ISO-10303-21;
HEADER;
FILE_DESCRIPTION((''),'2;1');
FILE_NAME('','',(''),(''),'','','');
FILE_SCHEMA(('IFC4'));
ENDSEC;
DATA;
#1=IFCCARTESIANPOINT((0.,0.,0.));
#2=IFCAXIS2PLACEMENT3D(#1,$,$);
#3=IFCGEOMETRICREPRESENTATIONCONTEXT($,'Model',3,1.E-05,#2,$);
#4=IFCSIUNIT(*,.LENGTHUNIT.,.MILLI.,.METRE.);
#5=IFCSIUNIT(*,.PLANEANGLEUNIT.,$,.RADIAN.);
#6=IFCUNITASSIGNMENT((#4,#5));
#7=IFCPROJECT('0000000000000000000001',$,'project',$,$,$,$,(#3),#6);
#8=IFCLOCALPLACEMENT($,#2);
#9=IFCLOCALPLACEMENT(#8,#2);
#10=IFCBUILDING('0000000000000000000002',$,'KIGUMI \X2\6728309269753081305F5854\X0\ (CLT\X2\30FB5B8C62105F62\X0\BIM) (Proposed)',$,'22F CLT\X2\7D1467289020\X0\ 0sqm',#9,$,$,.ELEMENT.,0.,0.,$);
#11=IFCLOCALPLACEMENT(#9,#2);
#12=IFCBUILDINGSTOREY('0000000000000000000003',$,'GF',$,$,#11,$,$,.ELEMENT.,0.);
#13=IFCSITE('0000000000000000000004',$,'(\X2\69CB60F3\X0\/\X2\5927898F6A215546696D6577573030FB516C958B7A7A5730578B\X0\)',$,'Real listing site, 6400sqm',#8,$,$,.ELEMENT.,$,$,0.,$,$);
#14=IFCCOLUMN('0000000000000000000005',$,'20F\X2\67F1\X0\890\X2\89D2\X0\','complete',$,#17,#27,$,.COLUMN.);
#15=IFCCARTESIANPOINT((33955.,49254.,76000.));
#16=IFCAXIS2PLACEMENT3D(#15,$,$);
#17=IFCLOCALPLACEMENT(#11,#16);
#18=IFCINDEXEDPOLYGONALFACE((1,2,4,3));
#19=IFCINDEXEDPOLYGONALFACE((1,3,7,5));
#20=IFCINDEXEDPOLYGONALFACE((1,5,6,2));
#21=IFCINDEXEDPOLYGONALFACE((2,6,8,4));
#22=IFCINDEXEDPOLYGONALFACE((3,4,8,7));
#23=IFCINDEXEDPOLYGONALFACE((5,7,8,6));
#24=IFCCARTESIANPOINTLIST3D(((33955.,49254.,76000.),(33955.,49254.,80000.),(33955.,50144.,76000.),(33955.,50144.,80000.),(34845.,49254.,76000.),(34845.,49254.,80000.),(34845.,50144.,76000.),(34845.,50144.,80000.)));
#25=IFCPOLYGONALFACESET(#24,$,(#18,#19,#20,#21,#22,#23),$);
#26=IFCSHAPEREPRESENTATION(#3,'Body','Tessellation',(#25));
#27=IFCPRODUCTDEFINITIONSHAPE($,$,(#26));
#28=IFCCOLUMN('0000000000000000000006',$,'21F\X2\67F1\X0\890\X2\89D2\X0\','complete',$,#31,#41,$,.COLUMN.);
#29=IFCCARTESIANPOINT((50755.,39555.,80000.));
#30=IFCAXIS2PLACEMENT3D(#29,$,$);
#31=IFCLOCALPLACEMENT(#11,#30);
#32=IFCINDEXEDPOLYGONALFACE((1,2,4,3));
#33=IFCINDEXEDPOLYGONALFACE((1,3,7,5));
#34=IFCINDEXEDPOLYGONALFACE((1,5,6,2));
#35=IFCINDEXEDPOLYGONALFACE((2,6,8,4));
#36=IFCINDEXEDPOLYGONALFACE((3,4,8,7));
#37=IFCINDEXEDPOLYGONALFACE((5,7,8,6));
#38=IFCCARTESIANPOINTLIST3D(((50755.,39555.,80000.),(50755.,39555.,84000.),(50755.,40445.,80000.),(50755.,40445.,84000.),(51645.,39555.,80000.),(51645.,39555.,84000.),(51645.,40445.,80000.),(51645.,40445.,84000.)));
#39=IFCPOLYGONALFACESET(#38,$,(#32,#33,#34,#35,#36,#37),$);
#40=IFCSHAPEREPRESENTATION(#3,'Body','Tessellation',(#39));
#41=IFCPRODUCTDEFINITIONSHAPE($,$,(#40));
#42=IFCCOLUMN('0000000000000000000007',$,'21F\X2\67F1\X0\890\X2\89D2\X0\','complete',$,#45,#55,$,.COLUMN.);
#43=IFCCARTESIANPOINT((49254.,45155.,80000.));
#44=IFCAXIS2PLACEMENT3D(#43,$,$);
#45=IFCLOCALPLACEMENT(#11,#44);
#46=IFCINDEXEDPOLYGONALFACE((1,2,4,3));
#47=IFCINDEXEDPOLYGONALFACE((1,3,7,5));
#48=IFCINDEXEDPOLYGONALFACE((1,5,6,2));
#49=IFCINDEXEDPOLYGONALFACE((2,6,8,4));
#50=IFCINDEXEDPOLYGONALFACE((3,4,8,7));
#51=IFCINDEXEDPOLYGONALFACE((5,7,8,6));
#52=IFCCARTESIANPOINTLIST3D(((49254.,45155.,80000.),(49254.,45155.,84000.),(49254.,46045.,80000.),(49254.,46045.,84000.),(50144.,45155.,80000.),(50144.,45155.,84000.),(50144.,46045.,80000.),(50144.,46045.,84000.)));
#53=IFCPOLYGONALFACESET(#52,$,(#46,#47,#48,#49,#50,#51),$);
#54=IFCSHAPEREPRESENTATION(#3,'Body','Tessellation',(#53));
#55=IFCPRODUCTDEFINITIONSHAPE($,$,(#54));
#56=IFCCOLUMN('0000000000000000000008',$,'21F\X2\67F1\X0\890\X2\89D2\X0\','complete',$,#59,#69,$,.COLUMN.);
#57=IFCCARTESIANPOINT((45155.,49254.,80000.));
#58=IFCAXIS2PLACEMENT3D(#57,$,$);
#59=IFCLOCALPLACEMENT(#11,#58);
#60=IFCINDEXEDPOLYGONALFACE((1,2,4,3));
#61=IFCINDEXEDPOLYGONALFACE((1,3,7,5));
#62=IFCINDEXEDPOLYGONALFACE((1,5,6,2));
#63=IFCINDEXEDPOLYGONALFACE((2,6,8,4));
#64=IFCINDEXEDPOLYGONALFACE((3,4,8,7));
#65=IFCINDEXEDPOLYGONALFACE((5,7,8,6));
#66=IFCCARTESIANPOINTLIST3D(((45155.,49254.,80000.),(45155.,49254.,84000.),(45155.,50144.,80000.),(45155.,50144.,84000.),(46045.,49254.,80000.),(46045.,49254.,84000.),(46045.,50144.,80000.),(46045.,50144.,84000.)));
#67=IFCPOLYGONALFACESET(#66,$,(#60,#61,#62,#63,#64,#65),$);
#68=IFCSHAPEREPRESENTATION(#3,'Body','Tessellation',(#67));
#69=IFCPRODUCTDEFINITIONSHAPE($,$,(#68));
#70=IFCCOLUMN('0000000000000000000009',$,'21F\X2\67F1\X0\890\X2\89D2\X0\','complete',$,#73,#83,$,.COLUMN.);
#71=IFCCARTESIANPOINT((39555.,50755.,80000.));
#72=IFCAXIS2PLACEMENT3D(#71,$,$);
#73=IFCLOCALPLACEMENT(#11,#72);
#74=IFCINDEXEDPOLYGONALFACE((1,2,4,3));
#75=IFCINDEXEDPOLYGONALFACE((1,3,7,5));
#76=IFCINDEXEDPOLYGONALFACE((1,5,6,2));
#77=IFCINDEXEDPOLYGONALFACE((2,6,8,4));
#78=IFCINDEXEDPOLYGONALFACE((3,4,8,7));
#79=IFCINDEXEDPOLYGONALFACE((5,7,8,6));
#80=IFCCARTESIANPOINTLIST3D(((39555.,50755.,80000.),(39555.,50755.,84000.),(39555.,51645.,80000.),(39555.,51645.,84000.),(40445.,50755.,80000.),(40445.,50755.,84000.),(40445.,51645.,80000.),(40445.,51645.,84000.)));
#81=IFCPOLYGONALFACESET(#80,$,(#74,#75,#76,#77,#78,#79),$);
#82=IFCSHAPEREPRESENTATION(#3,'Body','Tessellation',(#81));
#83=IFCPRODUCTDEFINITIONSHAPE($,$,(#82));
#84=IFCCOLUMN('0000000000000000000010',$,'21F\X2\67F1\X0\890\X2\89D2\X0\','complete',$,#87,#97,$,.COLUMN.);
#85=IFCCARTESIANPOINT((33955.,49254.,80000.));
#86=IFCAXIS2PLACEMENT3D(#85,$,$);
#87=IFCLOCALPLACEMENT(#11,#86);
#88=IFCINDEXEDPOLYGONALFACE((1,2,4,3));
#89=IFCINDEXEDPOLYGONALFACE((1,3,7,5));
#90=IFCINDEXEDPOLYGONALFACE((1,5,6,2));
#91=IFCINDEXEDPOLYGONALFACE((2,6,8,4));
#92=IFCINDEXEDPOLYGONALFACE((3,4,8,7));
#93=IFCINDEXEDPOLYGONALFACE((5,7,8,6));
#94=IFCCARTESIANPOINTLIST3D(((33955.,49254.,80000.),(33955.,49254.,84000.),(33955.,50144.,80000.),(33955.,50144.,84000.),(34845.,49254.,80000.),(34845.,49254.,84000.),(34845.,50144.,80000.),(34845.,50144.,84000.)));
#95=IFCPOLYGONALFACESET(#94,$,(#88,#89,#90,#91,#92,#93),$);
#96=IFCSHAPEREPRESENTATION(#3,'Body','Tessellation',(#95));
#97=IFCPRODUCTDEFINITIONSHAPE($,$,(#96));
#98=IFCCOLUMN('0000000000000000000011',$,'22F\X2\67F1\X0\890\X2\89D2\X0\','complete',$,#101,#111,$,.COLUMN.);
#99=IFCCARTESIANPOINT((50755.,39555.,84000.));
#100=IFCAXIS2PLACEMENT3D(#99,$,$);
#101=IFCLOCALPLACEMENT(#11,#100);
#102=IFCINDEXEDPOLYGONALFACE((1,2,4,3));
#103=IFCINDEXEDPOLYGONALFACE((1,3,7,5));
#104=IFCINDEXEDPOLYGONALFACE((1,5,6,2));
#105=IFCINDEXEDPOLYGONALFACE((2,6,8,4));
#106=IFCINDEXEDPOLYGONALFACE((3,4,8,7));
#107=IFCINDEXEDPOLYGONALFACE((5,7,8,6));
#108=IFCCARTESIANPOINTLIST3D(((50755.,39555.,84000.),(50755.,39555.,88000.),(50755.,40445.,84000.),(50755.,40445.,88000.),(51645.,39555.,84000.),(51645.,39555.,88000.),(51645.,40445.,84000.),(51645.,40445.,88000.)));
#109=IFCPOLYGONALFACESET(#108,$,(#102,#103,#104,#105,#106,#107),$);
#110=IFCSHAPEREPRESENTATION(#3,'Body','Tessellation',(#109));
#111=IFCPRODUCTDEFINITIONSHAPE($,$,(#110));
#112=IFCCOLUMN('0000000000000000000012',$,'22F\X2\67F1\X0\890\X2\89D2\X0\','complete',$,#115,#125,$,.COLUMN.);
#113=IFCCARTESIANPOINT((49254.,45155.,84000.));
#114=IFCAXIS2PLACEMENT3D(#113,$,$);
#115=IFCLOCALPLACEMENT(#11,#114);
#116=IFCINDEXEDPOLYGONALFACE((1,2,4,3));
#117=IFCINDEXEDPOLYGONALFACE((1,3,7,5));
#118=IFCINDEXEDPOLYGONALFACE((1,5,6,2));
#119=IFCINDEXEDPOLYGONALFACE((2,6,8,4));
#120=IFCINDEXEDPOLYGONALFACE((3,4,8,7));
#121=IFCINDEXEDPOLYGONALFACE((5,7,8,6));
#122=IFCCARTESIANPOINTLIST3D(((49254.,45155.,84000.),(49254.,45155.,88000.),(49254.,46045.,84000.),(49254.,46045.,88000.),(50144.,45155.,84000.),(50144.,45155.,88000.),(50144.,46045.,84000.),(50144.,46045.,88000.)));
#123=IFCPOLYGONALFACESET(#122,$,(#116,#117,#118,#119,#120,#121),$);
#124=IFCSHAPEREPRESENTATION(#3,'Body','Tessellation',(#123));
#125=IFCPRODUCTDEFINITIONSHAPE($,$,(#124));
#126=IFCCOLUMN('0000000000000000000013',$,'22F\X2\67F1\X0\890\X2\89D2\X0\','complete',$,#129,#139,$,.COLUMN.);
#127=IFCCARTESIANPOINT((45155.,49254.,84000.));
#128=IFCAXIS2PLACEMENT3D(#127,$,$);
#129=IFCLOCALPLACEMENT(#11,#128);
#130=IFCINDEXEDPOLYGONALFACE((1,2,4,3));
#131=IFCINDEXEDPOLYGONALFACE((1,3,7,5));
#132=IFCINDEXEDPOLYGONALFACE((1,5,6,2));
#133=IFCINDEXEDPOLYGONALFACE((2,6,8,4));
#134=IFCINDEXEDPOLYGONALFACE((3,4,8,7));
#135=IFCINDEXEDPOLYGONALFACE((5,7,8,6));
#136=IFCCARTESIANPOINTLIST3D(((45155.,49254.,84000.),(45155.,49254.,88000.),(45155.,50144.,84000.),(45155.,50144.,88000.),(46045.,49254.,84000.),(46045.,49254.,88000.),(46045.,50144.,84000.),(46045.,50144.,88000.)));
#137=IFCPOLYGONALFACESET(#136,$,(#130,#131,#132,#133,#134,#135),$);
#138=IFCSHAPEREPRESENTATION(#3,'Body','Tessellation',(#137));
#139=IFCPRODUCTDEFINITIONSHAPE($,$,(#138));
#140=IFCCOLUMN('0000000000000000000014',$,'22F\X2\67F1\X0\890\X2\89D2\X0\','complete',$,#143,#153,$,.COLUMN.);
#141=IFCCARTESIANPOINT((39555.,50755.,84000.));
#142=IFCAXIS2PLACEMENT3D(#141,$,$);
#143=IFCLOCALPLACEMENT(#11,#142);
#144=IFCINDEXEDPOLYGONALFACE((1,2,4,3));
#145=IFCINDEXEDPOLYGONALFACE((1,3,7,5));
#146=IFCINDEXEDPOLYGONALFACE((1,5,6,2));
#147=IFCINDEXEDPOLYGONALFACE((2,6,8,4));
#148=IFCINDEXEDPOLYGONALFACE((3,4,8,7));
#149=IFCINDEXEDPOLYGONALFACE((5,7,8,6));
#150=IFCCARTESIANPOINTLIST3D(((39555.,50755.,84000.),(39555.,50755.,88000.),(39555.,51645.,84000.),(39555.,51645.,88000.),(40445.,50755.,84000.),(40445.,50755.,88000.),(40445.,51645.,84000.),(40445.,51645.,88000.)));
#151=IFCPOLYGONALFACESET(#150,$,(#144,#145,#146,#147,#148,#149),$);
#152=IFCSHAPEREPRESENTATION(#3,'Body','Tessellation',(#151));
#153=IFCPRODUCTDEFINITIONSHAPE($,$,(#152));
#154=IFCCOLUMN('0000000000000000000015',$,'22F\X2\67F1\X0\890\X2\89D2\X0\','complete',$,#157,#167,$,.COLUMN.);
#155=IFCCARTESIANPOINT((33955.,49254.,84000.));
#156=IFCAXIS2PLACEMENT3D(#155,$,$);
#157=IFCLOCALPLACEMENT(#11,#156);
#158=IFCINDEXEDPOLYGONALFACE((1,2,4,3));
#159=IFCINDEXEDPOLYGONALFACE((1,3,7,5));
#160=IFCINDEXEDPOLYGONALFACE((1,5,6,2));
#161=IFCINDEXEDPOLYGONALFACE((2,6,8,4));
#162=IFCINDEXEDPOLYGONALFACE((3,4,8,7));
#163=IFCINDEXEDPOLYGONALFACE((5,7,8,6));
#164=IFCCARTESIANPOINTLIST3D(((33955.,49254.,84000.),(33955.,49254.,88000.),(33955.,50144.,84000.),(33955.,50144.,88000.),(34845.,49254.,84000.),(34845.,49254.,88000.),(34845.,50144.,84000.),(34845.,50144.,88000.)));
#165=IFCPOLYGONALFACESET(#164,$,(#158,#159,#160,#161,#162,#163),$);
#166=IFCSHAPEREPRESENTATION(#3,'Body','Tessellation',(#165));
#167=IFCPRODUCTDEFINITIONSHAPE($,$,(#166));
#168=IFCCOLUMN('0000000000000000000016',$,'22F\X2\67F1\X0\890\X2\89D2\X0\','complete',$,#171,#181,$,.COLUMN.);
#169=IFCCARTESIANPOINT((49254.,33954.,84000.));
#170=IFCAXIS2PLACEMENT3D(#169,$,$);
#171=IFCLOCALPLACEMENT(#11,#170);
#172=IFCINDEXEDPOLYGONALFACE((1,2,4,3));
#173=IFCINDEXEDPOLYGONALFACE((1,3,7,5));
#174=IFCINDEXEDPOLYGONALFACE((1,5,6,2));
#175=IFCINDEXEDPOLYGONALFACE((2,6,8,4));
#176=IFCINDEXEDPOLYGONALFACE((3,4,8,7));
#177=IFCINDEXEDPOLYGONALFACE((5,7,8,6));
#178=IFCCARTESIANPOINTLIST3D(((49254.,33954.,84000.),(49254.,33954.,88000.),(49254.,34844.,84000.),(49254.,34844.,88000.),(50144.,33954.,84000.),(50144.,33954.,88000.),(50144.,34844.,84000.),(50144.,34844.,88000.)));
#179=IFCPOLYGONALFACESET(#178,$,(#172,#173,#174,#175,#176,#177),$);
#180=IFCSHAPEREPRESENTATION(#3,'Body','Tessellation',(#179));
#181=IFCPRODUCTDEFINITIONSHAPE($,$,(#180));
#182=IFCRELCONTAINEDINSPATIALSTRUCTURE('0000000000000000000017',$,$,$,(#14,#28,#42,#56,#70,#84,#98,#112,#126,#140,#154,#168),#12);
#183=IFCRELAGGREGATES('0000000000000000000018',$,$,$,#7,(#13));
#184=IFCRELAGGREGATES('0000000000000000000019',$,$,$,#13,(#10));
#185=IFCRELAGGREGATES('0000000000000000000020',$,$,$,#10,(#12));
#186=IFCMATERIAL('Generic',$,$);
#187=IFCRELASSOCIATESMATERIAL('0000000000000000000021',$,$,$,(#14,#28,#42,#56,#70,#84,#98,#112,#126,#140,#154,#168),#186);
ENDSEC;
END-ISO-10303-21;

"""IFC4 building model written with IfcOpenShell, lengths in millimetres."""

from ifc_helpers import new_model, si_unit, frame, frame_2d, origin, place, context, project, spatial, rectangle, extrude, material, element, save


model = new_model("IFC4")

# Units and contexts
model_context = context("Model", 3, precision=1e-05, world=origin())
ifc_project = project(units=[si_unit("LENGTHUNIT", "METRE", prefix="MILLI"), si_unit("PLANEANGLEUNIT", "RADIAN")], contexts=[model_context])

# Site, building, storey
site_placement = place(None, origin())
site = spatial("IfcSite", under=ifc_project, at=site_placement, Name="(構想/大規模商業敷地・公開空地型)", ObjectType="Real listing site, 6400sqm", CompositionType="ELEMENT", RefElevation=0.0)
building_placement = place(site_placement, origin())
building = spatial("IfcBuilding", under=site, at=building_placement, Name="KIGUMI 木を極めた塔 (CLT・完成形BIM) (Proposed)", ObjectType="22F CLT純木造 0sqm", CompositionType="ELEMENT", ElevationOfRefHeight=0.0, ElevationOfTerrain=0.0)
storey_placement = place(building_placement, origin())
storey = spatial("IfcBuildingStorey", under=building, at=storey_placement, Name="GF", CompositionType="ELEMENT", Elevation=0.0)

# Columns
ifc_material = material(Name="Generic")
column_1_placement = place(storey_placement, frame((33955.0, 49254.0, 76000.0)))
element("IfcColumn", 1, at=column_1_placement, inside=storey, material=ifc_material, Name="20F柱890角", Description="complete", PredefinedType="COLUMN", context=model_context, shape_type="SweptSolid", body=[
    extrude(rectangle(XDim=890.0, YDim=890.0, at=frame_2d((445.0, 445.0))), frame((33955.0, 49254.0, 76000.0)), (0.0, 0.0, 1.0), 4000.0),
])
column_2_placement = place(storey_placement, frame((50755.0, 39555.0, 80000.0)))
element("IfcColumn", 2, at=column_2_placement, inside=storey, material=ifc_material, Name="21F柱890角", Description="complete", PredefinedType="COLUMN", context=model_context, shape_type="SweptSolid", body=[
    extrude(rectangle(XDim=890.0, YDim=890.0, at=frame_2d((445.0, 445.0))), frame((50755.0, 39555.0, 80000.0)), (0.0, 0.0, 1.0), 4000.0),
])
column_3_placement = place(storey_placement, frame((49254.0, 45155.0, 80000.0)))
element("IfcColumn", 3, at=column_3_placement, inside=storey, material=ifc_material, Name="21F柱890角", Description="complete", PredefinedType="COLUMN", context=model_context, shape_type="SweptSolid", body=[
    extrude(rectangle(XDim=890.0, YDim=890.0, at=frame_2d((445.0, 445.0))), frame((49254.0, 45155.0, 80000.0)), (0.0, 0.0, 1.0), 4000.0),
])
column_4_placement = place(storey_placement, frame((45155.0, 49254.0, 80000.0)))
element("IfcColumn", 4, at=column_4_placement, inside=storey, material=ifc_material, Name="21F柱890角", Description="complete", PredefinedType="COLUMN", context=model_context, shape_type="SweptSolid", body=[
    extrude(rectangle(XDim=890.0, YDim=890.0, at=frame_2d((445.0, 445.0))), frame((45155.0, 49254.0, 80000.0)), (0.0, 0.0, 1.0), 4000.0),
])
column_5_placement = place(storey_placement, frame((39555.0, 50755.0, 80000.0)))
element("IfcColumn", 5, at=column_5_placement, inside=storey, material=ifc_material, Name="21F柱890角", Description="complete", PredefinedType="COLUMN", context=model_context, shape_type="SweptSolid", body=[
    extrude(rectangle(XDim=890.0, YDim=890.0, at=frame_2d((445.0, 445.0))), frame((39555.0, 50755.0, 80000.0)), (0.0, 0.0, 1.0), 4000.0),
])
column_6_placement = place(storey_placement, frame((33955.0, 49254.0, 80000.0)))
element("IfcColumn", 6, at=column_6_placement, inside=storey, material=ifc_material, Name="21F柱890角", Description="complete", PredefinedType="COLUMN", context=model_context, shape_type="SweptSolid", body=[
    extrude(rectangle(XDim=890.0, YDim=890.0, at=frame_2d((445.0, 445.0))), frame((33955.0, 49254.0, 80000.0)), (0.0, 0.0, 1.0), 4000.0),
])
column_7_placement = place(storey_placement, frame((50755.0, 39555.0, 84000.0)))
element("IfcColumn", 7, at=column_7_placement, inside=storey, material=ifc_material, Name="22F柱890角", Description="complete", PredefinedType="COLUMN", context=model_context, shape_type="SweptSolid", body=[
    extrude(rectangle(XDim=890.0, YDim=890.0, at=frame_2d((445.0, 445.0))), frame((50755.0, 39555.0, 84000.0)), (0.0, 0.0, 1.0), 4000.0),
])
column_8_placement = place(storey_placement, frame((49254.0, 45155.0, 84000.0)))
element("IfcColumn", 8, at=column_8_placement, inside=storey, material=ifc_material, Name="22F柱890角", Description="complete", PredefinedType="COLUMN", context=model_context, shape_type="SweptSolid", body=[
    extrude(rectangle(XDim=890.0, YDim=890.0, at=frame_2d((445.0, 445.0))), frame((49254.0, 45155.0, 84000.0)), (0.0, 0.0, 1.0), 4000.0),
])
column_9_placement = place(storey_placement, frame((45155.0, 49254.0, 84000.0)))
element("IfcColumn", 9, at=column_9_placement, inside=storey, material=ifc_material, Name="22F柱890角", Description="complete", PredefinedType="COLUMN", context=model_context, shape_type="SweptSolid", body=[
    extrude(rectangle(XDim=890.0, YDim=890.0, at=frame_2d((445.0, 445.0))), frame((45155.0, 49254.0, 84000.0)), (0.0, 0.0, 1.0), 4000.0),
])
column_10_placement = place(storey_placement, frame((39555.0, 50755.0, 84000.0)))
element("IfcColumn", 10, at=column_10_placement, inside=storey, material=ifc_material, Name="22F柱890角", Description="complete", PredefinedType="COLUMN", context=model_context, shape_type="SweptSolid", body=[
    extrude(rectangle(XDim=890.0, YDim=890.0, at=frame_2d((445.0, 445.0))), frame((39555.0, 50755.0, 84000.0)), (0.0, 0.0, 1.0), 4000.0),
])
column_11_placement = place(storey_placement, frame((33955.0, 49254.0, 84000.0)))
element("IfcColumn", 11, at=column_11_placement, inside=storey, material=ifc_material, Name="22F柱890角", Description="complete", PredefinedType="COLUMN", context=model_context, shape_type="SweptSolid", body=[
    extrude(rectangle(XDim=890.0, YDim=890.0, at=frame_2d((445.0, 445.0))), frame((33955.0, 49254.0, 84000.0)), (0.0, 0.0, 1.0), 4000.0),
])
column_12_placement = place(storey_placement, frame((49254.0, 33954.0, 84000.0)))
element("IfcColumn", 12, at=column_12_placement, inside=storey, material=ifc_material, Name="22F柱890角", Description="complete", PredefinedType="COLUMN", context=model_context, shape_type="SweptSolid", body=[
    extrude(rectangle(XDim=890.0, YDim=890.0, at=frame_2d((445.0, 445.0))), frame((49254.0, 33954.0, 84000.0)), (0.0, 0.0, 1.0), 4000.0),
])

save(model, "model.ifc")
